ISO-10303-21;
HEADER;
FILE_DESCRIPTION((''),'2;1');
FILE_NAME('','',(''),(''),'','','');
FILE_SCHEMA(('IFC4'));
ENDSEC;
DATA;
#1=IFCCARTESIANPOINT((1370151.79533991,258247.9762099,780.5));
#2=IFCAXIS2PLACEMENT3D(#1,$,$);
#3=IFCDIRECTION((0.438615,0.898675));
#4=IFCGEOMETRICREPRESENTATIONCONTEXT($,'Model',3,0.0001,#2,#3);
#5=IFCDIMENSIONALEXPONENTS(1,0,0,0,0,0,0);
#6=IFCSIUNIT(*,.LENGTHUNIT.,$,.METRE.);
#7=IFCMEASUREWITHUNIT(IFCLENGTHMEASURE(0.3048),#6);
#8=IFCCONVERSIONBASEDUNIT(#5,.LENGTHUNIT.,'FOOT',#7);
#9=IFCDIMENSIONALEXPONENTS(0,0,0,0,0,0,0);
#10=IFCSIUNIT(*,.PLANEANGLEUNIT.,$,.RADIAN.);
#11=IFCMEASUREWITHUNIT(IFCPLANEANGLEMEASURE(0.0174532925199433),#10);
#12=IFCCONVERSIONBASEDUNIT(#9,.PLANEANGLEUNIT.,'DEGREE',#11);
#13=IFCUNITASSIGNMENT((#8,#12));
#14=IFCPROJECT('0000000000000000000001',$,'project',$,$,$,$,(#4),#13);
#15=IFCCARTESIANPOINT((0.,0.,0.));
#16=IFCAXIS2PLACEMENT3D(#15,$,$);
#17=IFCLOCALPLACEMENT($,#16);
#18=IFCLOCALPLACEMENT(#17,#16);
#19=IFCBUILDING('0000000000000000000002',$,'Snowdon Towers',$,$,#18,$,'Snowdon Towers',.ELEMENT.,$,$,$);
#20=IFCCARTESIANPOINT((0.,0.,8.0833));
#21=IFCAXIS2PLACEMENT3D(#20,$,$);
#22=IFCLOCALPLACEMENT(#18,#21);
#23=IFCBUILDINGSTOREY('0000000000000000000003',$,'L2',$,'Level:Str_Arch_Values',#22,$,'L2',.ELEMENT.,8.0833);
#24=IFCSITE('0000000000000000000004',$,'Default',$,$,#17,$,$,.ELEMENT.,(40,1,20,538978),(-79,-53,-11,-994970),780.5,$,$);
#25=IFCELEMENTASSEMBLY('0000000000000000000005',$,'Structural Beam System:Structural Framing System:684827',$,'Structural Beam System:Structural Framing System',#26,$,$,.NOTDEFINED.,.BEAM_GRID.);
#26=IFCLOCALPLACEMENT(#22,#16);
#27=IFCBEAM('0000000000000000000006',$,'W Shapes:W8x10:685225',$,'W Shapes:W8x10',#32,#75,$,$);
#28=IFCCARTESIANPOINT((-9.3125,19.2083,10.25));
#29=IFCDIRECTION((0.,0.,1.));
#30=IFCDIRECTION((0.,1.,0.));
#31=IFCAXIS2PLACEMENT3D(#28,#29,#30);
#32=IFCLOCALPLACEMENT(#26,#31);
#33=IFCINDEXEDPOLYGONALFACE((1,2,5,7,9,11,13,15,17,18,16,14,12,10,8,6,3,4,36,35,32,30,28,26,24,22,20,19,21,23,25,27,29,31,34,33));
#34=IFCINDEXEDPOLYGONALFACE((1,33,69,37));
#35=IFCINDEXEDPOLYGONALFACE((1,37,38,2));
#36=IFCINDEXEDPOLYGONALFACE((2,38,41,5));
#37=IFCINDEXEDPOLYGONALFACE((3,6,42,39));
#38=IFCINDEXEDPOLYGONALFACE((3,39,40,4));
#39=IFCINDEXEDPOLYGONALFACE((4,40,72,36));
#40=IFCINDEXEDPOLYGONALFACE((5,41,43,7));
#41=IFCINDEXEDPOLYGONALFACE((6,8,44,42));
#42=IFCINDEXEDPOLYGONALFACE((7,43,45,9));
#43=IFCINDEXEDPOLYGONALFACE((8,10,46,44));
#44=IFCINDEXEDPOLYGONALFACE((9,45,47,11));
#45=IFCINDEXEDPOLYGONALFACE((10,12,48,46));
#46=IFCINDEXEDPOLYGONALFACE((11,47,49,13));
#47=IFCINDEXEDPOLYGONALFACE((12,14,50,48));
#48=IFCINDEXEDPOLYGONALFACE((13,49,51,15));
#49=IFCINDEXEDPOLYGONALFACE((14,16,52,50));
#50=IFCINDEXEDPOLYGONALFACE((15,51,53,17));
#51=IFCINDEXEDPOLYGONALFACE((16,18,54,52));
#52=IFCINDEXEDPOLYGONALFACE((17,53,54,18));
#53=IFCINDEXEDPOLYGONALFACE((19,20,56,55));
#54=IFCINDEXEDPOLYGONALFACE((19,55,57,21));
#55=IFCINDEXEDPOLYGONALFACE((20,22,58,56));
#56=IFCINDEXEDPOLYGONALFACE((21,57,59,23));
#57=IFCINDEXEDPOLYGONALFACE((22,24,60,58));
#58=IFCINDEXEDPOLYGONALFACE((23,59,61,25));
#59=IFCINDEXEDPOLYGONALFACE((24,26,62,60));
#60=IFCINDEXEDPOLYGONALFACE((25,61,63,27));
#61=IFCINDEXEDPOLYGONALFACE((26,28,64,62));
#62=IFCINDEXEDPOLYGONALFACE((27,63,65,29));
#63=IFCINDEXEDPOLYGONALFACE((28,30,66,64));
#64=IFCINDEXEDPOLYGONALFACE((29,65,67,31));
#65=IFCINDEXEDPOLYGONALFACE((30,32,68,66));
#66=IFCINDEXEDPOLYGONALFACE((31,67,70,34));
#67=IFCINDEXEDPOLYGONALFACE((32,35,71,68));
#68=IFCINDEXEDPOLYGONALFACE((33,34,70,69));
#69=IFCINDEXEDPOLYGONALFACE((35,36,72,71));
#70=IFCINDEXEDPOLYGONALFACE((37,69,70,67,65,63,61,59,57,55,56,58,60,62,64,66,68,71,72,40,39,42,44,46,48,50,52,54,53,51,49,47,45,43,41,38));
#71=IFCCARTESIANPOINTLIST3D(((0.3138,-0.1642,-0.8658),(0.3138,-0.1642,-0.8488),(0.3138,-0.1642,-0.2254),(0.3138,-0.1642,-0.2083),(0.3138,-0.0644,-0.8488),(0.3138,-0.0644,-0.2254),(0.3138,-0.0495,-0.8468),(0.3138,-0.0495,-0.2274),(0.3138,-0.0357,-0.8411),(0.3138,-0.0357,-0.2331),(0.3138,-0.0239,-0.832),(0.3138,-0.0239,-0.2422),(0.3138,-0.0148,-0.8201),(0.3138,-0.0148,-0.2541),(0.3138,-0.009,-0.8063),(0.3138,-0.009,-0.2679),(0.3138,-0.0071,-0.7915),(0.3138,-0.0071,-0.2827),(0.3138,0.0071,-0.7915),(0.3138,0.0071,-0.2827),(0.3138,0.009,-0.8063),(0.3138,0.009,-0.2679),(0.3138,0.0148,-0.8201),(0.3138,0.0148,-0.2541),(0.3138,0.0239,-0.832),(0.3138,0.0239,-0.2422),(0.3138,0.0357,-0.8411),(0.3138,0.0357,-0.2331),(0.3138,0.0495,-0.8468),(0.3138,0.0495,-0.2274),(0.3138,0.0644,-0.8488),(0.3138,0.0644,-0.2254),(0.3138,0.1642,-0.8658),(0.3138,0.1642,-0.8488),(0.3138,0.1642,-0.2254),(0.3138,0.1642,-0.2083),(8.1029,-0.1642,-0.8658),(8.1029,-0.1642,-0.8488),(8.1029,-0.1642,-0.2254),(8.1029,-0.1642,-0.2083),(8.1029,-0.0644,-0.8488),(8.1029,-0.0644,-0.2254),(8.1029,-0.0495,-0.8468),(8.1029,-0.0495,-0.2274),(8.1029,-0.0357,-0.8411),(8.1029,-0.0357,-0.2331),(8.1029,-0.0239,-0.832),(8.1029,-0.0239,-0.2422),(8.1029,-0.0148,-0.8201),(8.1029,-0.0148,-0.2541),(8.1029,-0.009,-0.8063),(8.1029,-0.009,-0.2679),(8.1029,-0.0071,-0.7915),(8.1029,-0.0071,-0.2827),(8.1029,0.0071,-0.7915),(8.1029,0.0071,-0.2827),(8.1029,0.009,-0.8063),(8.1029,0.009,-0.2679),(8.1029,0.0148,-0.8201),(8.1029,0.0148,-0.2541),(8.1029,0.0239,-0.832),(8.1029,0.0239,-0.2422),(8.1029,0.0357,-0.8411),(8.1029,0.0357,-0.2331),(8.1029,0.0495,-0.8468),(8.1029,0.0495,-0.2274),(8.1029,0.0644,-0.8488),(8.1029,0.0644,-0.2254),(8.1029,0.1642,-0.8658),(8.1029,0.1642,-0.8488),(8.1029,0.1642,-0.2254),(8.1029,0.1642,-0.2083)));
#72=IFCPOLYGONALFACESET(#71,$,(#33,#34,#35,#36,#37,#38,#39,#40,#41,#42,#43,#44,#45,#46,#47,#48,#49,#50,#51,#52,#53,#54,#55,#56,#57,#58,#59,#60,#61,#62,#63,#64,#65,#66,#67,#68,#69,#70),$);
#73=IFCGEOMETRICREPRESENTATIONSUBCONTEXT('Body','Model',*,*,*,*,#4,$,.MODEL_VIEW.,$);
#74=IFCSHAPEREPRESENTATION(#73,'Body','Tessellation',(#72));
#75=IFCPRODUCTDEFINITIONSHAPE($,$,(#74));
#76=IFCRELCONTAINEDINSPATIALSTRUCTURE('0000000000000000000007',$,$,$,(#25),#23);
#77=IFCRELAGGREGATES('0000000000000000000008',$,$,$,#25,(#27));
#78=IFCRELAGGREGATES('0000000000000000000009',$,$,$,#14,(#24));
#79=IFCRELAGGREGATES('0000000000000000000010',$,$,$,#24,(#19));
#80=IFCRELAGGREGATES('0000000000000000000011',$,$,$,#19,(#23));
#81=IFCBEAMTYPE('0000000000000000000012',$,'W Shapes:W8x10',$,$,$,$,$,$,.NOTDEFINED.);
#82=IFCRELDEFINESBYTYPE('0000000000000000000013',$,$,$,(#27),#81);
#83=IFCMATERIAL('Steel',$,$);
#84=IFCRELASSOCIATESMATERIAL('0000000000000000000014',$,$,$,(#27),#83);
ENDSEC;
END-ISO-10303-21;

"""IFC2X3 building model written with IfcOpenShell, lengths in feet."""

from ifc_helpers import new_model, entity, si_unit, converted_unit, direction, frame, frame_2d, origin, place, context, subcontext, project, spatial, i_section, extrude, material, type_object, element, aggregate, save


model = new_model("IFC2X3")

# Units and contexts
model_context = context("Model", 3, precision=0.0001, world=frame((1370151.79533991, 258247.9762099, 780.5)), true_north=direction((0.438615, 0.898675)))
body_context = subcontext(model_context, "Body", "Model", "MODEL_VIEW")
ifc_project = project(units=[converted_unit("LENGTHUNIT", "FOOT", entity("IfcLengthMeasure", 0.3048), si_unit("LENGTHUNIT", "METRE"), dimensions=[1, 0, 0, 0, 0, 0, 0]), converted_unit("PLANEANGLEUNIT", "DEGREE", entity("IfcPlaneAngleMeasure", 0.0174532925199433), si_unit("PLANEANGLEUNIT", "RADIAN"), dimensions=[0, 0, 0, 0, 0, 0, 0])], contexts=[model_context])

# Site, building, storey
site_placement = place(None, origin())
site = spatial("IfcSite", under=ifc_project, at=site_placement, Name="Default", CompositionType="ELEMENT", RefLatitude=(40, 1, 20, 538978), RefLongitude=(-79, -53, -11, -994970), RefElevation=780.5)
building_placement = place(site_placement, origin())
building = spatial("IfcBuilding", under=site, at=building_placement, Name="Snowdon Towers", LongName="Snowdon Towers", CompositionType="ELEMENT")
storey_placement = place(building_placement, frame((0.0, 0.0, 8.0833)))
storey = spatial("IfcBuildingStorey", under=building, at=storey_placement, Name="L2", ObjectType="Level:Str_Arch_Values", LongName="L2", CompositionType="ELEMENT", Elevation=8.0833)

# Shared definitions
ifc_material = material(Name="Steel")
beam_type_1 = type_object("IfcBeamType", Name="W Shapes:W8x10", PredefinedType="NOTDEFINED")

# Element assembly, beam
assembly_placement = place(storey_placement, origin())
assembly = element("IfcElementAssembly", 1, at=assembly_placement, inside=storey, Name="Structural Beam System:Structural Framing System:684827", ObjectType="Structural Beam System:Structural Framing System", AssemblyPlace="NOTDEFINED", PredefinedType="BEAM_GRID")
beam_1_placement = place(assembly_placement, frame((-9.3125, 19.2083, 10.25), z_axis=(0.0, 0.0, 1.0), x_axis=(0.0, 1.0, 0.0)))
beam_1 = element("IfcBeam", 2, at=beam_1_placement, type_object=beam_type_1, material=ifc_material, Name="W Shapes:W8x10:685225", ObjectType="W Shapes:W8x10", context=body_context, shape_type="SweptSolid", body=[
    extrude(i_section(OverallWidth=0.3283, OverallDepth=0.6575, WebThickness=0.0142, FlangeThickness=0.0171, FilletRadius=0.0573, at=frame_2d((0.0, 0.0), x_axis=(0.0, 1.0))), frame((0.3138, 0.0, -0.5371), z_axis=(1.0, 0.0, 0.0), x_axis=(0.0, 0.0, -1.0)), (0.0, 0.0, 1.0), 7.7892),
])
aggregate(assembly, [beam_1])

save(model, "model.ifc")
